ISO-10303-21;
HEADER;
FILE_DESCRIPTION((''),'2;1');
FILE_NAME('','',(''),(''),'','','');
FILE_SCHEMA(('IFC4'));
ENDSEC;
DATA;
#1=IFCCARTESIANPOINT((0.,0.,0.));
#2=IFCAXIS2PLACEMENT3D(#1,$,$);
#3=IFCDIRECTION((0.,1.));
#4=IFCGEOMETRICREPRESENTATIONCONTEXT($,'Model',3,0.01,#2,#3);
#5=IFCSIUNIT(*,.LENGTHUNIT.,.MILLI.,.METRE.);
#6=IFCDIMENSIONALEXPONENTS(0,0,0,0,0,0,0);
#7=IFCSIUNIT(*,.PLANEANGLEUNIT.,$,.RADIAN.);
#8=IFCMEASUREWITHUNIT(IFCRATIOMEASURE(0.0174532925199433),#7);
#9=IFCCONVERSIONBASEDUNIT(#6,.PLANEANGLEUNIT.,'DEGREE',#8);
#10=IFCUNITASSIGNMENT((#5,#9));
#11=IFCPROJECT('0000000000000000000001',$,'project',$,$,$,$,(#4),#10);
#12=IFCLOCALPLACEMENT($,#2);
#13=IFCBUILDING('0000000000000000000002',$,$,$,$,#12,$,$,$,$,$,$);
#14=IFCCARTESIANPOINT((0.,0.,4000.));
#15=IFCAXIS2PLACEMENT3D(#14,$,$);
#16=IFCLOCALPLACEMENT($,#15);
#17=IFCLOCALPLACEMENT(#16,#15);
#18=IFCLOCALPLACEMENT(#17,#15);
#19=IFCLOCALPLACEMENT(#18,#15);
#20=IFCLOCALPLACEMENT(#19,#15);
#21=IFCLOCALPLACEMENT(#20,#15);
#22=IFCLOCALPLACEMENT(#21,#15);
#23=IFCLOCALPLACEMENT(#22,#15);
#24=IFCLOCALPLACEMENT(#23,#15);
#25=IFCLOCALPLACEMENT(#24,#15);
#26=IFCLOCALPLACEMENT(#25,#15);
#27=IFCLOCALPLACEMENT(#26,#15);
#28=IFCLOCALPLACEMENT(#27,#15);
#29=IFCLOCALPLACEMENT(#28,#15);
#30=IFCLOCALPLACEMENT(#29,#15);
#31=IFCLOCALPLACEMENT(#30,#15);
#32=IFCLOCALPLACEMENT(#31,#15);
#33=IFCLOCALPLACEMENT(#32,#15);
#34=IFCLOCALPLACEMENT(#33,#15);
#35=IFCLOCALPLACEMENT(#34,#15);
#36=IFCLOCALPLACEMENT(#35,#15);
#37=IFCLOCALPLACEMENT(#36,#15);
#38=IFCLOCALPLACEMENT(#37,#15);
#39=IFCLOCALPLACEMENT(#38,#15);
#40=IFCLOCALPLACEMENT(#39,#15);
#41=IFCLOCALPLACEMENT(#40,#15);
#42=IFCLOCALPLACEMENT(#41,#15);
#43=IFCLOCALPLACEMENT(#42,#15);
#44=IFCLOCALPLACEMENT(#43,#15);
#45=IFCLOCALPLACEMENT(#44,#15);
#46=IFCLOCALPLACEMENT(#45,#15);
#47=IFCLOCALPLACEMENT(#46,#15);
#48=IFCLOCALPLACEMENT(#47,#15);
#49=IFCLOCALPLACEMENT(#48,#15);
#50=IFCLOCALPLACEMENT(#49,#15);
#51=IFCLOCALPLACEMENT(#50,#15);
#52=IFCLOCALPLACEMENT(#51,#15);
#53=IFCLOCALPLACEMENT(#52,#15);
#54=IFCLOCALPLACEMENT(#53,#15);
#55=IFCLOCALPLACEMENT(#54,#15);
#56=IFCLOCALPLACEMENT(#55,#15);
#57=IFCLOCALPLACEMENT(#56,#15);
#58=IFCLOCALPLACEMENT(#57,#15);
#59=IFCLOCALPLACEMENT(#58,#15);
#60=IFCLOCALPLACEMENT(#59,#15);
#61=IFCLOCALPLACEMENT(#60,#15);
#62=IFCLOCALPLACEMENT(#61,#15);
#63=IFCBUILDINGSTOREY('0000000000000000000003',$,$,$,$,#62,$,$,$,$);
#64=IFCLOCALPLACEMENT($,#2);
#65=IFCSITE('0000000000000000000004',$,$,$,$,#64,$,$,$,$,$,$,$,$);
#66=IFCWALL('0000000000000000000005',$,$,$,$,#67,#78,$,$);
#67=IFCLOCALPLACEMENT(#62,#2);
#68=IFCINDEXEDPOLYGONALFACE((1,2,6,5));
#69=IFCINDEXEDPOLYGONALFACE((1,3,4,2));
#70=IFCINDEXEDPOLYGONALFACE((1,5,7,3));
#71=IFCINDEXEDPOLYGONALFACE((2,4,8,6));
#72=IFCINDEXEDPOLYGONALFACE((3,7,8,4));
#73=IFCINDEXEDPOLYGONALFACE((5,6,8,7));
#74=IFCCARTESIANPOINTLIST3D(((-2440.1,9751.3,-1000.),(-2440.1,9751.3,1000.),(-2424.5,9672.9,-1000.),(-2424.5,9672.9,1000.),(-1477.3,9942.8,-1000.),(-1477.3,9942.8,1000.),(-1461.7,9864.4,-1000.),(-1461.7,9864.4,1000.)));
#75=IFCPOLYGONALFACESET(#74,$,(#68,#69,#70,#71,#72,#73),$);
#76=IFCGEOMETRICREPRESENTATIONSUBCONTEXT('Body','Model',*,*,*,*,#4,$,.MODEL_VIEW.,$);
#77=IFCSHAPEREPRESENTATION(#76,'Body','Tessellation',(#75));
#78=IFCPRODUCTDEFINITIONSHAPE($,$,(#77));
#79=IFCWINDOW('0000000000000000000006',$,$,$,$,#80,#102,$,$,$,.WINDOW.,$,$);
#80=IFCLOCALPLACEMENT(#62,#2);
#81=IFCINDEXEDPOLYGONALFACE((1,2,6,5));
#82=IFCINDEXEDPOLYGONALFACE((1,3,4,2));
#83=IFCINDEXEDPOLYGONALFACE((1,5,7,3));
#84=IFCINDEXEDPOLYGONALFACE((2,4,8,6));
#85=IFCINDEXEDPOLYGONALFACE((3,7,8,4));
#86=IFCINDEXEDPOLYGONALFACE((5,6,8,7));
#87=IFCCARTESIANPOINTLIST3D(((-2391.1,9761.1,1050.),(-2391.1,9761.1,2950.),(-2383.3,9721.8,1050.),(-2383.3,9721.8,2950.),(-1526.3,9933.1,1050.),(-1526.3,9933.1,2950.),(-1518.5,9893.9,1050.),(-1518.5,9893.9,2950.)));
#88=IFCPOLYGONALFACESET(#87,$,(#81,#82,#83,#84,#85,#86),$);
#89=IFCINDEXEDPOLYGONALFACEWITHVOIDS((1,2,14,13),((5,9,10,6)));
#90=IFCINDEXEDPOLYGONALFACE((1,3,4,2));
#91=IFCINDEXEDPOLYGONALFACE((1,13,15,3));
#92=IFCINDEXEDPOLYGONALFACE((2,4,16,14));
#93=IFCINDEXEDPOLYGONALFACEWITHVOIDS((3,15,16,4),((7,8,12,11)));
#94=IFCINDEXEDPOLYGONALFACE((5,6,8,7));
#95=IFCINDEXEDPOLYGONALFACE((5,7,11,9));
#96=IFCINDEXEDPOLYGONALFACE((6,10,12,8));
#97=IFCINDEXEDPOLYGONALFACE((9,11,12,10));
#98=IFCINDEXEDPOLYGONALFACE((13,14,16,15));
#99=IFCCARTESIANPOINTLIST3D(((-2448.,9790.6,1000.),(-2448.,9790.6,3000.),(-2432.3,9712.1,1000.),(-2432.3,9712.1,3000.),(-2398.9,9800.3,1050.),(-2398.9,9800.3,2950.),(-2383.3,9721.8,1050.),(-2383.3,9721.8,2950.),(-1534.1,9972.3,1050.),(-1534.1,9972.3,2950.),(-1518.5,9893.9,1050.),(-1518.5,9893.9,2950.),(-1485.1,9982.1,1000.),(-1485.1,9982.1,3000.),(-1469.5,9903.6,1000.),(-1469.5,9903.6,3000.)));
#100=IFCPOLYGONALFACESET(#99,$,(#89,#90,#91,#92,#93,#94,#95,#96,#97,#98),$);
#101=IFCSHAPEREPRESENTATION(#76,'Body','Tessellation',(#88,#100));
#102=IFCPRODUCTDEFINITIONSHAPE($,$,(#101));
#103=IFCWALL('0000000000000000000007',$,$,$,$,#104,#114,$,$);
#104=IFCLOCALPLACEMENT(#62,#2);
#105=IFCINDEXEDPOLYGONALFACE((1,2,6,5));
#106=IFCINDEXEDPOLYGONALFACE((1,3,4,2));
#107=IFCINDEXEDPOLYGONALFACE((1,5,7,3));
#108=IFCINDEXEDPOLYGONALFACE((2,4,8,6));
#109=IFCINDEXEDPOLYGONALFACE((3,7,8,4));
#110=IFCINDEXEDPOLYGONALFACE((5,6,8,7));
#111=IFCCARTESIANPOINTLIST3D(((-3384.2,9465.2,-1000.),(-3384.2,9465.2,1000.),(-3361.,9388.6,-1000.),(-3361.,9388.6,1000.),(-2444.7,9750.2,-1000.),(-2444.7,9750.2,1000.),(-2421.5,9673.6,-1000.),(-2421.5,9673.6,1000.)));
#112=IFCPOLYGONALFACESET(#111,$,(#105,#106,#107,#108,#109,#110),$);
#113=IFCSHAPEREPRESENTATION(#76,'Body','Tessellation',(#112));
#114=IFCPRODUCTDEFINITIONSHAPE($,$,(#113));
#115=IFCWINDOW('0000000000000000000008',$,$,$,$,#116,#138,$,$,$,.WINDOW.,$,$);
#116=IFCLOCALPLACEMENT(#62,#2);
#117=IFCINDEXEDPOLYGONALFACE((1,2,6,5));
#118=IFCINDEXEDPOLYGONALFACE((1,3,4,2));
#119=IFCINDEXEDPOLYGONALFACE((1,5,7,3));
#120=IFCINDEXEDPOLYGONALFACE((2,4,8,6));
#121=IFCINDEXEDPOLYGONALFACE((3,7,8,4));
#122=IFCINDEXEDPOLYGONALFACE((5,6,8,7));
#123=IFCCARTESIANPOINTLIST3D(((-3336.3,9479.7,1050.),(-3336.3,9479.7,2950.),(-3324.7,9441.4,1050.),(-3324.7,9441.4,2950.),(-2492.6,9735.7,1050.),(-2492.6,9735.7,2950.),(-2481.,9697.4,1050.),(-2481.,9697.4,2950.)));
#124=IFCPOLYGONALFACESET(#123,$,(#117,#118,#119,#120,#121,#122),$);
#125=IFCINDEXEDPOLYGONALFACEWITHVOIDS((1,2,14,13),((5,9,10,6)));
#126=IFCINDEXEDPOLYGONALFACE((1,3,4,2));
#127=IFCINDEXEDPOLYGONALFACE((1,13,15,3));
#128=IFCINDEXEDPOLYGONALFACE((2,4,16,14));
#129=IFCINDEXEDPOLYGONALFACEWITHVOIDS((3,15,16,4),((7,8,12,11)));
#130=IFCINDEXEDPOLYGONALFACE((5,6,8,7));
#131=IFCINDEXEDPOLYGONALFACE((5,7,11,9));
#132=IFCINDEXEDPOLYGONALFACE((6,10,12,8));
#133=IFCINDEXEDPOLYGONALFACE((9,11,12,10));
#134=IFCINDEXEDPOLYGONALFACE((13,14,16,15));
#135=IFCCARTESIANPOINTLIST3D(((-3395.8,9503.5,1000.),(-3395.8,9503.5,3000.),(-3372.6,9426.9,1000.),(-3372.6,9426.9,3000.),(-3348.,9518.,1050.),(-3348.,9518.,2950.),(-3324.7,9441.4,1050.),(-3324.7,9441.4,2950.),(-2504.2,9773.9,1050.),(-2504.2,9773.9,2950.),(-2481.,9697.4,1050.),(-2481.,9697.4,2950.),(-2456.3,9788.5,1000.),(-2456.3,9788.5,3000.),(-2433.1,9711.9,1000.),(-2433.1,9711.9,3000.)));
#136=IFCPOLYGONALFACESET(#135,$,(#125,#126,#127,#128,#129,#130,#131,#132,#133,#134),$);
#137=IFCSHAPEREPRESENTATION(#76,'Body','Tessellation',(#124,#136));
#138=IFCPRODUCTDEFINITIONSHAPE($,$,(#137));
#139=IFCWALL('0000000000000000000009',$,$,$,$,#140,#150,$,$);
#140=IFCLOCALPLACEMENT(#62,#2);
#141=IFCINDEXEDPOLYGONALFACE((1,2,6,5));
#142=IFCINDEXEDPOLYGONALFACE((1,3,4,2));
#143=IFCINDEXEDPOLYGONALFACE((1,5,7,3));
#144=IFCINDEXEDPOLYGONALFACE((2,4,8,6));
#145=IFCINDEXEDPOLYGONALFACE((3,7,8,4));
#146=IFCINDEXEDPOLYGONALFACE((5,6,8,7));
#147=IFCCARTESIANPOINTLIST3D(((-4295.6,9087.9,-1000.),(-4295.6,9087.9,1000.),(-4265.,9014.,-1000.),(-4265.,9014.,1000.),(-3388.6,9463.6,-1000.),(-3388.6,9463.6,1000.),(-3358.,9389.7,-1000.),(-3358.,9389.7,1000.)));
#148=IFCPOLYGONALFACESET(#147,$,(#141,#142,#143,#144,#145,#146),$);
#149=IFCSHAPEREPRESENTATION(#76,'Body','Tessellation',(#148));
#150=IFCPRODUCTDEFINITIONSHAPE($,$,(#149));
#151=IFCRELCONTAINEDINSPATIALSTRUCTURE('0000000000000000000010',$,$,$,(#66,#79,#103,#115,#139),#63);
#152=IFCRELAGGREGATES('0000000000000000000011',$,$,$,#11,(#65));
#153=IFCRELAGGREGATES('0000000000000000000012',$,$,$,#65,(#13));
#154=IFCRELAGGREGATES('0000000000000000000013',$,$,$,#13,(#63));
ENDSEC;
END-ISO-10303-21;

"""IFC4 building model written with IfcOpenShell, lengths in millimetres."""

from ifc_helpers import new_model, entity, si_unit, converted_unit, direction, frame, origin, origin_2d, place, context, subcontext, project, spatial, rectangle, extrude, element, save


model = new_model("IFC4")

# Units and contexts
model_context = context("Model", 3, precision=0.01, world=origin(), true_north=direction((0.0, 1.0)))
body_context = subcontext(model_context, "Body", "Model", "MODEL_VIEW")
ifc_project = project(units=[si_unit("LENGTHUNIT", "METRE", prefix="MILLI"), converted_unit("PLANEANGLEUNIT", "DEGREE", entity("IfcRatioMeasure", 0.0174532925199433), si_unit("PLANEANGLEUNIT", "RADIAN"), dimensions=[0, 0, 0, 0, 0, 0, 0])], contexts=[model_context])

# Site, building, storey
site_placement = place(None, origin())
site = spatial("IfcSite", under=ifc_project, at=site_placement)
building_placement = place(None, origin())
building = spatial("IfcBuilding", under=site, at=building_placement)
placement_1 = place(None, frame((0.0, 0.0, 4000.0)))
placement_2 = place(placement_1, frame((0.0, 0.0, 4000.0)))
placement_3 = place(placement_2, frame((0.0, 0.0, 4000.0)))
placement_4 = place(placement_3, frame((0.0, 0.0, 4000.0)))
placement_5 = place(placement_4, frame((0.0, 0.0, 4000.0)))
placement_6 = place(placement_5, frame((0.0, 0.0, 4000.0)))
placement_7 = place(placement_6, frame((0.0, 0.0, 4000.0)))
placement_8 = place(placement_7, frame((0.0, 0.0, 4000.0)))
placement_9 = place(placement_8, frame((0.0, 0.0, 4000.0)))
placement_10 = place(placement_9, frame((0.0, 0.0, 4000.0)))
placement_11 = place(placement_10, frame((0.0, 0.0, 4000.0)))
placement_12 = place(placement_11, frame((0.0, 0.0, 4000.0)))
placement_13 = place(placement_12, frame((0.0, 0.0, 4000.0)))
placement_14 = place(placement_13, frame((0.0, 0.0, 4000.0)))
placement_15 = place(placement_14, frame((0.0, 0.0, 4000.0)))
placement_16 = place(placement_15, frame((0.0, 0.0, 4000.0)))
placement_17 = place(placement_16, frame((0.0, 0.0, 4000.0)))
placement_18 = place(placement_17, frame((0.0, 0.0, 4000.0)))
placement_19 = place(placement_18, frame((0.0, 0.0, 4000.0)))
placement_20 = place(placement_19, frame((0.0, 0.0, 4000.0)))
placement_21 = place(placement_20, frame((0.0, 0.0, 4000.0)))
placement_22 = place(placement_21, frame((0.0, 0.0, 4000.0)))
placement_23 = place(placement_22, frame((0.0, 0.0, 4000.0)))
placement_24 = place(placement_23, frame((0.0, 0.0, 4000.0)))
placement_25 = place(placement_24, frame((0.0, 0.0, 4000.0)))
placement_26 = place(placement_25, frame((0.0, 0.0, 4000.0)))
placement_27 = place(placement_26, frame((0.0, 0.0, 4000.0)))
placement_28 = place(placement_27, frame((0.0, 0.0, 4000.0)))
placement_29 = place(placement_28, frame((0.0, 0.0, 4000.0)))
placement_30 = place(placement_29, frame((0.0, 0.0, 4000.0)))
placement_31 = place(placement_30, frame((0.0, 0.0, 4000.0)))
placement_32 = place(placement_31, frame((0.0, 0.0, 4000.0)))
placement_33 = place(placement_32, frame((0.0, 0.0, 4000.0)))
placement_34 = place(placement_33, frame((0.0, 0.0, 4000.0)))
placement_35 = place(placement_34, frame((0.0, 0.0, 4000.0)))
placement_36 = place(placement_35, frame((0.0, 0.0, 4000.0)))
placement_37 = place(placement_36, frame((0.0, 0.0, 4000.0)))
placement_38 = place(placement_37, frame((0.0, 0.0, 4000.0)))
placement_39 = place(placement_38, frame((0.0, 0.0, 4000.0)))
placement_40 = place(placement_39, frame((0.0, 0.0, 4000.0)))
placement_41 = place(placement_40, frame((0.0, 0.0, 4000.0)))
placement_42 = place(placement_41, frame((0.0, 0.0, 4000.0)))
placement_43 = place(placement_42, frame((0.0, 0.0, 4000.0)))
placement_44 = place(placement_43, frame((0.0, 0.0, 4000.0)))
placement_45 = place(placement_44, frame((0.0, 0.0, 4000.0)))
placement_46 = place(placement_45, frame((0.0, 0.0, 4000.0)))
storey_placement = place(placement_46, frame((0.0, 0.0, 4000.0)))
storey = spatial("IfcBuildingStorey", under=building, at=storey_placement)

# Shared definitions
cartesian_point_1 = entity("IfcCartesianPoint", [-440.9, -950.0])
shared_polyline = entity("IfcPolyline", [cartesian_point_1, entity("IfcCartesianPoint", [-440.9, 950.0]), entity("IfcCartesianPoint", [-440.9, 950.0]), entity("IfcCartesianPoint", [440.9, 950.0]), entity("IfcCartesianPoint", [440.9, 950.0]), entity("IfcCartesianPoint", [440.9, -950.0]), entity("IfcCartesianPoint", [440.9, -950.0]), entity("IfcCartesianPoint", [-440.9, -950.0]), cartesian_point_1])

# Wall
wall_1_placement = place(storey_placement, frame((-1950.9, 9807.9, -1000.0), z_axis=(0.0, 0.0, 1.0), x_axis=(-9807.852795, -1950.903264, 0.0)))
element("IfcWall", 1, at=wall_1_placement, inside=storey, context=body_context, shape_type="SweptSolid", body=[
    extrude(rectangle(XDim=981.7, YDim=80.0, at=origin_2d()), origin(), (0.0, 0.0, 1.0), 2000.0),
])

# Window
window_1_placement = place(storey_placement, frame((-1950.9, 9807.9, 2000.0), z_axis=(0.0, 0.0, 1.0), x_axis=(-9807.852795, -1950.903264, 0.0)))
cartesian_point_2 = entity("IfcCartesianPoint", [-490.9, -1000.0])
element("IfcWindow", 2, at=window_1_placement, inside=storey, PredefinedType="WINDOW", context=body_context, shape_type="SweptSolid", body=[
    entity("IfcExtrudedAreaSolid", entity("IfcArbitraryClosedProfileDef", "AREA", None, shared_polyline), entity("IfcAxis2Placement3D", entity("IfcCartesianPoint", [0.0, 0.0, 0.0]), entity("IfcDirection", [0.0, -1.0, 0.0]), entity("IfcDirection", [1.0, 0.0, 0.0])), entity("IfcDirection", [0.0, 0.0, 1.0]), 40.0),
    entity("IfcExtrudedAreaSolid", entity("IfcArbitraryProfileDefWithVoids", "AREA", None, entity("IfcPolyline", [cartesian_point_2, entity("IfcCartesianPoint", [-490.9, 1000.0]), entity("IfcCartesianPoint", [-490.9, 1000.0]), entity("IfcCartesianPoint", [490.9, 1000.0]), entity("IfcCartesianPoint", [490.9, 1000.0]), entity("IfcCartesianPoint", [490.9, -1000.0]), entity("IfcCartesianPoint", [490.9, -1000.0]), entity("IfcCartesianPoint", [-490.9, -1000.0]), cartesian_point_2]), [shared_polyline]), entity("IfcAxis2Placement3D", entity("IfcCartesianPoint", [0.0, 0.0, 0.0]), entity("IfcDirection", [0.0, -1.0, 0.0]), entity("IfcDirection", [1.0, 0.0, 0.0])), entity("IfcDirection", [0.0, 0.0, 1.0]), 80.0),
])

# Wall
wall_2_placement = place(storey_placement, frame((-2902.8, 9569.4, -1000.0), z_axis=(0.0, 0.0, 1.0), x_axis=(-9569.403228, -2902.847198, 0.0)))
element("IfcWall", 3, at=wall_2_placement, inside=storey, context=body_context, shape_type="SweptSolid", body=[
    extrude(rectangle(XDim=981.7, YDim=80.0, at=origin_2d()), origin(), (0.0, 0.0, 1.0), 2000.0),
])

# Window
window_2_placement = place(storey_placement, frame((-2902.8, 9569.4, 2000.0), z_axis=(0.0, 0.0, 1.0), x_axis=(-9569.403228, -2902.847198, 0.0)))
cartesian_point_3 = entity("IfcCartesianPoint", [-490.9, -1000.0])
element("IfcWindow", 4, at=window_2_placement, inside=storey, PredefinedType="WINDOW", context=body_context, shape_type="SweptSolid", body=[
    entity("IfcExtrudedAreaSolid", entity("IfcArbitraryClosedProfileDef", "AREA", None, shared_polyline), entity("IfcAxis2Placement3D", entity("IfcCartesianPoint", [0.0, 0.0, 0.0]), entity("IfcDirection", [0.0, -1.0, 0.0]), entity("IfcDirection", [1.0, 0.0, 0.0])), entity("IfcDirection", [0.0, 0.0, 1.0]), 40.0),
    entity("IfcExtrudedAreaSolid", entity("IfcArbitraryProfileDefWithVoids", "AREA", None, entity("IfcPolyline", [cartesian_point_3, entity("IfcCartesianPoint", [-490.9, 1000.0]), entity("IfcCartesianPoint", [-490.9, 1000.0]), entity("IfcCartesianPoint", [490.9, 1000.0]), entity("IfcCartesianPoint", [490.9, 1000.0]), entity("IfcCartesianPoint", [490.9, -1000.0]), entity("IfcCartesianPoint", [490.9, -1000.0]), entity("IfcCartesianPoint", [-490.9, -1000.0]), cartesian_point_3]), [shared_polyline]), entity("IfcAxis2Placement3D", entity("IfcCartesianPoint", [0.0, 0.0, 0.0]), entity("IfcDirection", [0.0, -1.0, 0.0]), entity("IfcDirection", [1.0, 0.0, 0.0])), entity("IfcDirection", [0.0, 0.0, 1.0]), 80.0),
])

# Wall
wall_3_placement = place(storey_placement, frame((-3826.8, 9238.8, -1000.0), z_axis=(0.0, 0.0, 1.0), x_axis=(-9238.795458, -3826.834002, 0.0)))
element("IfcWall", 5, at=wall_3_placement, inside=storey, context=body_context, shape_type="SweptSolid", body=[
    extrude(rectangle(XDim=981.7, YDim=80.0, at=origin_2d()), origin(), (0.0, 0.0, 1.0), 2000.0),
])

save(model, "model.ifc")
